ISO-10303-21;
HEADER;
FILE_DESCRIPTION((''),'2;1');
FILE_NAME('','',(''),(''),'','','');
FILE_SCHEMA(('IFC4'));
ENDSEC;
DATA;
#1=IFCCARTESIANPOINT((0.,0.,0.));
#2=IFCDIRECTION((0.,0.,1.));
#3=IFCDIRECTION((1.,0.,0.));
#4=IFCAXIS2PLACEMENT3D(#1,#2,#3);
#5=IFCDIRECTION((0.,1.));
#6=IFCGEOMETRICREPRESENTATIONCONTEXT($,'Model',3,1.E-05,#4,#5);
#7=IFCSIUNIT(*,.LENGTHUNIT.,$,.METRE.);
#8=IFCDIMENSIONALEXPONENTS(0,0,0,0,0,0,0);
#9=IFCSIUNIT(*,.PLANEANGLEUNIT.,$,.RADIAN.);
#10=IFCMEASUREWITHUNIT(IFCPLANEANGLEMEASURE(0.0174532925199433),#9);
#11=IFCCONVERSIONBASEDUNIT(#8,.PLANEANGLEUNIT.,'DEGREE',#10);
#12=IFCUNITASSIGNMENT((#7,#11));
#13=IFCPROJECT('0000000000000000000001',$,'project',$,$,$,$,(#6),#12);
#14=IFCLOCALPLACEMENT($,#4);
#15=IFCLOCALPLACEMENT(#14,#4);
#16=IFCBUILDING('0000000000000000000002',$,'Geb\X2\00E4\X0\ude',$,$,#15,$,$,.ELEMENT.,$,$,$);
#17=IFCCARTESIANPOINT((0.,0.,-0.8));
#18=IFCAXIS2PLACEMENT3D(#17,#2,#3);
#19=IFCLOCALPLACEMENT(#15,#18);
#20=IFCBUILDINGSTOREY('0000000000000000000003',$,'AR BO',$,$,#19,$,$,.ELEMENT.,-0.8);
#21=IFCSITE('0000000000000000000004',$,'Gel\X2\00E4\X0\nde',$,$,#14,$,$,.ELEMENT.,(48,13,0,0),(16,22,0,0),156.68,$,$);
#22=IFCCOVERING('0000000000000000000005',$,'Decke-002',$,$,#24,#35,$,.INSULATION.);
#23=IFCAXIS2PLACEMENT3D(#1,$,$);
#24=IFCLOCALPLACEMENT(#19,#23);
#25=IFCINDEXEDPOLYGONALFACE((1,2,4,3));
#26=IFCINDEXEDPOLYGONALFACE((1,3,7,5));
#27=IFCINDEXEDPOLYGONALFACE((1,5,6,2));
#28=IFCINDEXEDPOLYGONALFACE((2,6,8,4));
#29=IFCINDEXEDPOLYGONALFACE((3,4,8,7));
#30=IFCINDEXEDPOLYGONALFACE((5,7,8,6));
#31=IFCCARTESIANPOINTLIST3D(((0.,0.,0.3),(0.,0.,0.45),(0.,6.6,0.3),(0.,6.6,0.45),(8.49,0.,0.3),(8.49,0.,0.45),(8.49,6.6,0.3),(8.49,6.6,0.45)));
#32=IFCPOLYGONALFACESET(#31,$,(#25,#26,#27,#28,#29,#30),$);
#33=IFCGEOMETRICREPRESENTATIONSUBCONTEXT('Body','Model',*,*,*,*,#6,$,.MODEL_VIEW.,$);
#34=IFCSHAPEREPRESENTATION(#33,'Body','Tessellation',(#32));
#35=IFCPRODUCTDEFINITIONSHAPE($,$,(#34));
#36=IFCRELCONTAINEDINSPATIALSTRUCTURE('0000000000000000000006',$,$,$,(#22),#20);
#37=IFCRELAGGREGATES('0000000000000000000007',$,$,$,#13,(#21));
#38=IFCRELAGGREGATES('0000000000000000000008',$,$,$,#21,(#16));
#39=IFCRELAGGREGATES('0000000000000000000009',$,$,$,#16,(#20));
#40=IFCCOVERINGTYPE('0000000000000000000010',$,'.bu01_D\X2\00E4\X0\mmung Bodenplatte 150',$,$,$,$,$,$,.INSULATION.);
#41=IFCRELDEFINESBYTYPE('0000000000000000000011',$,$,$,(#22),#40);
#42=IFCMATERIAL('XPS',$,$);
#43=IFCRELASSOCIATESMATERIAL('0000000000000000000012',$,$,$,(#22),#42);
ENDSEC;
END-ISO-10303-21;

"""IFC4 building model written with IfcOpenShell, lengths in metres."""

from ifc_helpers import new_model, entity, si_unit, converted_unit, direction, frame, origin_with_axes, place, context, subcontext, project, spatial, line, indexed_curve, outline, extrude, material, type_object, element, save


model = new_model("IFC4")

# Units and contexts
model_context = context("Model", 3, precision=1e-05, world=origin_with_axes(), true_north=direction((0.0, 1.0)))
body_context = subcontext(model_context, "Body", "Model", "MODEL_VIEW")
ifc_project = project(units=[si_unit("LENGTHUNIT", "METRE"), converted_unit("PLANEANGLEUNIT", "DEGREE", entity("IfcPlaneAngleMeasure", 0.0174532925199433), si_unit("PLANEANGLEUNIT", "RADIAN"), dimensions=[0, 0, 0, 0, 0, 0, 0])], contexts=[model_context])

# Site, building, storey
site_placement = place(None, origin_with_axes())
site = spatial("IfcSite", under=ifc_project, at=site_placement, Name="Gelände", CompositionType="ELEMENT", RefLatitude=(48, 13, 0, 0), RefLongitude=(16, 22, 0, 0), RefElevation=156.68)
building_placement = place(site_placement, origin_with_axes())
building = spatial("IfcBuilding", under=site, at=building_placement, Name="Gebäude", CompositionType="ELEMENT")
storey_placement = place(building_placement, frame((0.0, 0.0, -0.8), z_axis=(0.0, 0.0, 1.0), x_axis=(1.0, 0.0, 0.0)))
storey = spatial("IfcBuildingStorey", under=building, at=storey_placement, Name="AR BO", CompositionType="ELEMENT", Elevation=-0.8)

# Covering
ifc_material = material(Name="XPS")
covering_type = type_object("IfcCoveringType", Name=".bu01_Dämmung Bodenplatte 150", PredefinedType="INSULATION")
covering_placement = place(storey_placement, frame((0.0, 0.0, 0.45), z_axis=(0.0, 0.0, 1.0), x_axis=(1.0, 0.0, 0.0)))
element("IfcCovering", 1, at=covering_placement, inside=storey, type_object=covering_type, material=ifc_material, Name="Decke-002", PredefinedType="INSULATION", context=body_context, shape_type="SweptSolid", body=[
    extrude(outline(indexed_curve([(0.0, 0.0), (8.49, 0.0), (8.49, 6.6), (0.0, 6.6)], segments=[line(1, 2, 3, 4, 1)])), frame((0.0, 0.0, -0.15), z_axis=(0.0, 0.0, 1.0), x_axis=(1.0, 0.0, 0.0)), (0.0, 0.0, 1.0), 0.15),
])

save(model, "model.ifc")
